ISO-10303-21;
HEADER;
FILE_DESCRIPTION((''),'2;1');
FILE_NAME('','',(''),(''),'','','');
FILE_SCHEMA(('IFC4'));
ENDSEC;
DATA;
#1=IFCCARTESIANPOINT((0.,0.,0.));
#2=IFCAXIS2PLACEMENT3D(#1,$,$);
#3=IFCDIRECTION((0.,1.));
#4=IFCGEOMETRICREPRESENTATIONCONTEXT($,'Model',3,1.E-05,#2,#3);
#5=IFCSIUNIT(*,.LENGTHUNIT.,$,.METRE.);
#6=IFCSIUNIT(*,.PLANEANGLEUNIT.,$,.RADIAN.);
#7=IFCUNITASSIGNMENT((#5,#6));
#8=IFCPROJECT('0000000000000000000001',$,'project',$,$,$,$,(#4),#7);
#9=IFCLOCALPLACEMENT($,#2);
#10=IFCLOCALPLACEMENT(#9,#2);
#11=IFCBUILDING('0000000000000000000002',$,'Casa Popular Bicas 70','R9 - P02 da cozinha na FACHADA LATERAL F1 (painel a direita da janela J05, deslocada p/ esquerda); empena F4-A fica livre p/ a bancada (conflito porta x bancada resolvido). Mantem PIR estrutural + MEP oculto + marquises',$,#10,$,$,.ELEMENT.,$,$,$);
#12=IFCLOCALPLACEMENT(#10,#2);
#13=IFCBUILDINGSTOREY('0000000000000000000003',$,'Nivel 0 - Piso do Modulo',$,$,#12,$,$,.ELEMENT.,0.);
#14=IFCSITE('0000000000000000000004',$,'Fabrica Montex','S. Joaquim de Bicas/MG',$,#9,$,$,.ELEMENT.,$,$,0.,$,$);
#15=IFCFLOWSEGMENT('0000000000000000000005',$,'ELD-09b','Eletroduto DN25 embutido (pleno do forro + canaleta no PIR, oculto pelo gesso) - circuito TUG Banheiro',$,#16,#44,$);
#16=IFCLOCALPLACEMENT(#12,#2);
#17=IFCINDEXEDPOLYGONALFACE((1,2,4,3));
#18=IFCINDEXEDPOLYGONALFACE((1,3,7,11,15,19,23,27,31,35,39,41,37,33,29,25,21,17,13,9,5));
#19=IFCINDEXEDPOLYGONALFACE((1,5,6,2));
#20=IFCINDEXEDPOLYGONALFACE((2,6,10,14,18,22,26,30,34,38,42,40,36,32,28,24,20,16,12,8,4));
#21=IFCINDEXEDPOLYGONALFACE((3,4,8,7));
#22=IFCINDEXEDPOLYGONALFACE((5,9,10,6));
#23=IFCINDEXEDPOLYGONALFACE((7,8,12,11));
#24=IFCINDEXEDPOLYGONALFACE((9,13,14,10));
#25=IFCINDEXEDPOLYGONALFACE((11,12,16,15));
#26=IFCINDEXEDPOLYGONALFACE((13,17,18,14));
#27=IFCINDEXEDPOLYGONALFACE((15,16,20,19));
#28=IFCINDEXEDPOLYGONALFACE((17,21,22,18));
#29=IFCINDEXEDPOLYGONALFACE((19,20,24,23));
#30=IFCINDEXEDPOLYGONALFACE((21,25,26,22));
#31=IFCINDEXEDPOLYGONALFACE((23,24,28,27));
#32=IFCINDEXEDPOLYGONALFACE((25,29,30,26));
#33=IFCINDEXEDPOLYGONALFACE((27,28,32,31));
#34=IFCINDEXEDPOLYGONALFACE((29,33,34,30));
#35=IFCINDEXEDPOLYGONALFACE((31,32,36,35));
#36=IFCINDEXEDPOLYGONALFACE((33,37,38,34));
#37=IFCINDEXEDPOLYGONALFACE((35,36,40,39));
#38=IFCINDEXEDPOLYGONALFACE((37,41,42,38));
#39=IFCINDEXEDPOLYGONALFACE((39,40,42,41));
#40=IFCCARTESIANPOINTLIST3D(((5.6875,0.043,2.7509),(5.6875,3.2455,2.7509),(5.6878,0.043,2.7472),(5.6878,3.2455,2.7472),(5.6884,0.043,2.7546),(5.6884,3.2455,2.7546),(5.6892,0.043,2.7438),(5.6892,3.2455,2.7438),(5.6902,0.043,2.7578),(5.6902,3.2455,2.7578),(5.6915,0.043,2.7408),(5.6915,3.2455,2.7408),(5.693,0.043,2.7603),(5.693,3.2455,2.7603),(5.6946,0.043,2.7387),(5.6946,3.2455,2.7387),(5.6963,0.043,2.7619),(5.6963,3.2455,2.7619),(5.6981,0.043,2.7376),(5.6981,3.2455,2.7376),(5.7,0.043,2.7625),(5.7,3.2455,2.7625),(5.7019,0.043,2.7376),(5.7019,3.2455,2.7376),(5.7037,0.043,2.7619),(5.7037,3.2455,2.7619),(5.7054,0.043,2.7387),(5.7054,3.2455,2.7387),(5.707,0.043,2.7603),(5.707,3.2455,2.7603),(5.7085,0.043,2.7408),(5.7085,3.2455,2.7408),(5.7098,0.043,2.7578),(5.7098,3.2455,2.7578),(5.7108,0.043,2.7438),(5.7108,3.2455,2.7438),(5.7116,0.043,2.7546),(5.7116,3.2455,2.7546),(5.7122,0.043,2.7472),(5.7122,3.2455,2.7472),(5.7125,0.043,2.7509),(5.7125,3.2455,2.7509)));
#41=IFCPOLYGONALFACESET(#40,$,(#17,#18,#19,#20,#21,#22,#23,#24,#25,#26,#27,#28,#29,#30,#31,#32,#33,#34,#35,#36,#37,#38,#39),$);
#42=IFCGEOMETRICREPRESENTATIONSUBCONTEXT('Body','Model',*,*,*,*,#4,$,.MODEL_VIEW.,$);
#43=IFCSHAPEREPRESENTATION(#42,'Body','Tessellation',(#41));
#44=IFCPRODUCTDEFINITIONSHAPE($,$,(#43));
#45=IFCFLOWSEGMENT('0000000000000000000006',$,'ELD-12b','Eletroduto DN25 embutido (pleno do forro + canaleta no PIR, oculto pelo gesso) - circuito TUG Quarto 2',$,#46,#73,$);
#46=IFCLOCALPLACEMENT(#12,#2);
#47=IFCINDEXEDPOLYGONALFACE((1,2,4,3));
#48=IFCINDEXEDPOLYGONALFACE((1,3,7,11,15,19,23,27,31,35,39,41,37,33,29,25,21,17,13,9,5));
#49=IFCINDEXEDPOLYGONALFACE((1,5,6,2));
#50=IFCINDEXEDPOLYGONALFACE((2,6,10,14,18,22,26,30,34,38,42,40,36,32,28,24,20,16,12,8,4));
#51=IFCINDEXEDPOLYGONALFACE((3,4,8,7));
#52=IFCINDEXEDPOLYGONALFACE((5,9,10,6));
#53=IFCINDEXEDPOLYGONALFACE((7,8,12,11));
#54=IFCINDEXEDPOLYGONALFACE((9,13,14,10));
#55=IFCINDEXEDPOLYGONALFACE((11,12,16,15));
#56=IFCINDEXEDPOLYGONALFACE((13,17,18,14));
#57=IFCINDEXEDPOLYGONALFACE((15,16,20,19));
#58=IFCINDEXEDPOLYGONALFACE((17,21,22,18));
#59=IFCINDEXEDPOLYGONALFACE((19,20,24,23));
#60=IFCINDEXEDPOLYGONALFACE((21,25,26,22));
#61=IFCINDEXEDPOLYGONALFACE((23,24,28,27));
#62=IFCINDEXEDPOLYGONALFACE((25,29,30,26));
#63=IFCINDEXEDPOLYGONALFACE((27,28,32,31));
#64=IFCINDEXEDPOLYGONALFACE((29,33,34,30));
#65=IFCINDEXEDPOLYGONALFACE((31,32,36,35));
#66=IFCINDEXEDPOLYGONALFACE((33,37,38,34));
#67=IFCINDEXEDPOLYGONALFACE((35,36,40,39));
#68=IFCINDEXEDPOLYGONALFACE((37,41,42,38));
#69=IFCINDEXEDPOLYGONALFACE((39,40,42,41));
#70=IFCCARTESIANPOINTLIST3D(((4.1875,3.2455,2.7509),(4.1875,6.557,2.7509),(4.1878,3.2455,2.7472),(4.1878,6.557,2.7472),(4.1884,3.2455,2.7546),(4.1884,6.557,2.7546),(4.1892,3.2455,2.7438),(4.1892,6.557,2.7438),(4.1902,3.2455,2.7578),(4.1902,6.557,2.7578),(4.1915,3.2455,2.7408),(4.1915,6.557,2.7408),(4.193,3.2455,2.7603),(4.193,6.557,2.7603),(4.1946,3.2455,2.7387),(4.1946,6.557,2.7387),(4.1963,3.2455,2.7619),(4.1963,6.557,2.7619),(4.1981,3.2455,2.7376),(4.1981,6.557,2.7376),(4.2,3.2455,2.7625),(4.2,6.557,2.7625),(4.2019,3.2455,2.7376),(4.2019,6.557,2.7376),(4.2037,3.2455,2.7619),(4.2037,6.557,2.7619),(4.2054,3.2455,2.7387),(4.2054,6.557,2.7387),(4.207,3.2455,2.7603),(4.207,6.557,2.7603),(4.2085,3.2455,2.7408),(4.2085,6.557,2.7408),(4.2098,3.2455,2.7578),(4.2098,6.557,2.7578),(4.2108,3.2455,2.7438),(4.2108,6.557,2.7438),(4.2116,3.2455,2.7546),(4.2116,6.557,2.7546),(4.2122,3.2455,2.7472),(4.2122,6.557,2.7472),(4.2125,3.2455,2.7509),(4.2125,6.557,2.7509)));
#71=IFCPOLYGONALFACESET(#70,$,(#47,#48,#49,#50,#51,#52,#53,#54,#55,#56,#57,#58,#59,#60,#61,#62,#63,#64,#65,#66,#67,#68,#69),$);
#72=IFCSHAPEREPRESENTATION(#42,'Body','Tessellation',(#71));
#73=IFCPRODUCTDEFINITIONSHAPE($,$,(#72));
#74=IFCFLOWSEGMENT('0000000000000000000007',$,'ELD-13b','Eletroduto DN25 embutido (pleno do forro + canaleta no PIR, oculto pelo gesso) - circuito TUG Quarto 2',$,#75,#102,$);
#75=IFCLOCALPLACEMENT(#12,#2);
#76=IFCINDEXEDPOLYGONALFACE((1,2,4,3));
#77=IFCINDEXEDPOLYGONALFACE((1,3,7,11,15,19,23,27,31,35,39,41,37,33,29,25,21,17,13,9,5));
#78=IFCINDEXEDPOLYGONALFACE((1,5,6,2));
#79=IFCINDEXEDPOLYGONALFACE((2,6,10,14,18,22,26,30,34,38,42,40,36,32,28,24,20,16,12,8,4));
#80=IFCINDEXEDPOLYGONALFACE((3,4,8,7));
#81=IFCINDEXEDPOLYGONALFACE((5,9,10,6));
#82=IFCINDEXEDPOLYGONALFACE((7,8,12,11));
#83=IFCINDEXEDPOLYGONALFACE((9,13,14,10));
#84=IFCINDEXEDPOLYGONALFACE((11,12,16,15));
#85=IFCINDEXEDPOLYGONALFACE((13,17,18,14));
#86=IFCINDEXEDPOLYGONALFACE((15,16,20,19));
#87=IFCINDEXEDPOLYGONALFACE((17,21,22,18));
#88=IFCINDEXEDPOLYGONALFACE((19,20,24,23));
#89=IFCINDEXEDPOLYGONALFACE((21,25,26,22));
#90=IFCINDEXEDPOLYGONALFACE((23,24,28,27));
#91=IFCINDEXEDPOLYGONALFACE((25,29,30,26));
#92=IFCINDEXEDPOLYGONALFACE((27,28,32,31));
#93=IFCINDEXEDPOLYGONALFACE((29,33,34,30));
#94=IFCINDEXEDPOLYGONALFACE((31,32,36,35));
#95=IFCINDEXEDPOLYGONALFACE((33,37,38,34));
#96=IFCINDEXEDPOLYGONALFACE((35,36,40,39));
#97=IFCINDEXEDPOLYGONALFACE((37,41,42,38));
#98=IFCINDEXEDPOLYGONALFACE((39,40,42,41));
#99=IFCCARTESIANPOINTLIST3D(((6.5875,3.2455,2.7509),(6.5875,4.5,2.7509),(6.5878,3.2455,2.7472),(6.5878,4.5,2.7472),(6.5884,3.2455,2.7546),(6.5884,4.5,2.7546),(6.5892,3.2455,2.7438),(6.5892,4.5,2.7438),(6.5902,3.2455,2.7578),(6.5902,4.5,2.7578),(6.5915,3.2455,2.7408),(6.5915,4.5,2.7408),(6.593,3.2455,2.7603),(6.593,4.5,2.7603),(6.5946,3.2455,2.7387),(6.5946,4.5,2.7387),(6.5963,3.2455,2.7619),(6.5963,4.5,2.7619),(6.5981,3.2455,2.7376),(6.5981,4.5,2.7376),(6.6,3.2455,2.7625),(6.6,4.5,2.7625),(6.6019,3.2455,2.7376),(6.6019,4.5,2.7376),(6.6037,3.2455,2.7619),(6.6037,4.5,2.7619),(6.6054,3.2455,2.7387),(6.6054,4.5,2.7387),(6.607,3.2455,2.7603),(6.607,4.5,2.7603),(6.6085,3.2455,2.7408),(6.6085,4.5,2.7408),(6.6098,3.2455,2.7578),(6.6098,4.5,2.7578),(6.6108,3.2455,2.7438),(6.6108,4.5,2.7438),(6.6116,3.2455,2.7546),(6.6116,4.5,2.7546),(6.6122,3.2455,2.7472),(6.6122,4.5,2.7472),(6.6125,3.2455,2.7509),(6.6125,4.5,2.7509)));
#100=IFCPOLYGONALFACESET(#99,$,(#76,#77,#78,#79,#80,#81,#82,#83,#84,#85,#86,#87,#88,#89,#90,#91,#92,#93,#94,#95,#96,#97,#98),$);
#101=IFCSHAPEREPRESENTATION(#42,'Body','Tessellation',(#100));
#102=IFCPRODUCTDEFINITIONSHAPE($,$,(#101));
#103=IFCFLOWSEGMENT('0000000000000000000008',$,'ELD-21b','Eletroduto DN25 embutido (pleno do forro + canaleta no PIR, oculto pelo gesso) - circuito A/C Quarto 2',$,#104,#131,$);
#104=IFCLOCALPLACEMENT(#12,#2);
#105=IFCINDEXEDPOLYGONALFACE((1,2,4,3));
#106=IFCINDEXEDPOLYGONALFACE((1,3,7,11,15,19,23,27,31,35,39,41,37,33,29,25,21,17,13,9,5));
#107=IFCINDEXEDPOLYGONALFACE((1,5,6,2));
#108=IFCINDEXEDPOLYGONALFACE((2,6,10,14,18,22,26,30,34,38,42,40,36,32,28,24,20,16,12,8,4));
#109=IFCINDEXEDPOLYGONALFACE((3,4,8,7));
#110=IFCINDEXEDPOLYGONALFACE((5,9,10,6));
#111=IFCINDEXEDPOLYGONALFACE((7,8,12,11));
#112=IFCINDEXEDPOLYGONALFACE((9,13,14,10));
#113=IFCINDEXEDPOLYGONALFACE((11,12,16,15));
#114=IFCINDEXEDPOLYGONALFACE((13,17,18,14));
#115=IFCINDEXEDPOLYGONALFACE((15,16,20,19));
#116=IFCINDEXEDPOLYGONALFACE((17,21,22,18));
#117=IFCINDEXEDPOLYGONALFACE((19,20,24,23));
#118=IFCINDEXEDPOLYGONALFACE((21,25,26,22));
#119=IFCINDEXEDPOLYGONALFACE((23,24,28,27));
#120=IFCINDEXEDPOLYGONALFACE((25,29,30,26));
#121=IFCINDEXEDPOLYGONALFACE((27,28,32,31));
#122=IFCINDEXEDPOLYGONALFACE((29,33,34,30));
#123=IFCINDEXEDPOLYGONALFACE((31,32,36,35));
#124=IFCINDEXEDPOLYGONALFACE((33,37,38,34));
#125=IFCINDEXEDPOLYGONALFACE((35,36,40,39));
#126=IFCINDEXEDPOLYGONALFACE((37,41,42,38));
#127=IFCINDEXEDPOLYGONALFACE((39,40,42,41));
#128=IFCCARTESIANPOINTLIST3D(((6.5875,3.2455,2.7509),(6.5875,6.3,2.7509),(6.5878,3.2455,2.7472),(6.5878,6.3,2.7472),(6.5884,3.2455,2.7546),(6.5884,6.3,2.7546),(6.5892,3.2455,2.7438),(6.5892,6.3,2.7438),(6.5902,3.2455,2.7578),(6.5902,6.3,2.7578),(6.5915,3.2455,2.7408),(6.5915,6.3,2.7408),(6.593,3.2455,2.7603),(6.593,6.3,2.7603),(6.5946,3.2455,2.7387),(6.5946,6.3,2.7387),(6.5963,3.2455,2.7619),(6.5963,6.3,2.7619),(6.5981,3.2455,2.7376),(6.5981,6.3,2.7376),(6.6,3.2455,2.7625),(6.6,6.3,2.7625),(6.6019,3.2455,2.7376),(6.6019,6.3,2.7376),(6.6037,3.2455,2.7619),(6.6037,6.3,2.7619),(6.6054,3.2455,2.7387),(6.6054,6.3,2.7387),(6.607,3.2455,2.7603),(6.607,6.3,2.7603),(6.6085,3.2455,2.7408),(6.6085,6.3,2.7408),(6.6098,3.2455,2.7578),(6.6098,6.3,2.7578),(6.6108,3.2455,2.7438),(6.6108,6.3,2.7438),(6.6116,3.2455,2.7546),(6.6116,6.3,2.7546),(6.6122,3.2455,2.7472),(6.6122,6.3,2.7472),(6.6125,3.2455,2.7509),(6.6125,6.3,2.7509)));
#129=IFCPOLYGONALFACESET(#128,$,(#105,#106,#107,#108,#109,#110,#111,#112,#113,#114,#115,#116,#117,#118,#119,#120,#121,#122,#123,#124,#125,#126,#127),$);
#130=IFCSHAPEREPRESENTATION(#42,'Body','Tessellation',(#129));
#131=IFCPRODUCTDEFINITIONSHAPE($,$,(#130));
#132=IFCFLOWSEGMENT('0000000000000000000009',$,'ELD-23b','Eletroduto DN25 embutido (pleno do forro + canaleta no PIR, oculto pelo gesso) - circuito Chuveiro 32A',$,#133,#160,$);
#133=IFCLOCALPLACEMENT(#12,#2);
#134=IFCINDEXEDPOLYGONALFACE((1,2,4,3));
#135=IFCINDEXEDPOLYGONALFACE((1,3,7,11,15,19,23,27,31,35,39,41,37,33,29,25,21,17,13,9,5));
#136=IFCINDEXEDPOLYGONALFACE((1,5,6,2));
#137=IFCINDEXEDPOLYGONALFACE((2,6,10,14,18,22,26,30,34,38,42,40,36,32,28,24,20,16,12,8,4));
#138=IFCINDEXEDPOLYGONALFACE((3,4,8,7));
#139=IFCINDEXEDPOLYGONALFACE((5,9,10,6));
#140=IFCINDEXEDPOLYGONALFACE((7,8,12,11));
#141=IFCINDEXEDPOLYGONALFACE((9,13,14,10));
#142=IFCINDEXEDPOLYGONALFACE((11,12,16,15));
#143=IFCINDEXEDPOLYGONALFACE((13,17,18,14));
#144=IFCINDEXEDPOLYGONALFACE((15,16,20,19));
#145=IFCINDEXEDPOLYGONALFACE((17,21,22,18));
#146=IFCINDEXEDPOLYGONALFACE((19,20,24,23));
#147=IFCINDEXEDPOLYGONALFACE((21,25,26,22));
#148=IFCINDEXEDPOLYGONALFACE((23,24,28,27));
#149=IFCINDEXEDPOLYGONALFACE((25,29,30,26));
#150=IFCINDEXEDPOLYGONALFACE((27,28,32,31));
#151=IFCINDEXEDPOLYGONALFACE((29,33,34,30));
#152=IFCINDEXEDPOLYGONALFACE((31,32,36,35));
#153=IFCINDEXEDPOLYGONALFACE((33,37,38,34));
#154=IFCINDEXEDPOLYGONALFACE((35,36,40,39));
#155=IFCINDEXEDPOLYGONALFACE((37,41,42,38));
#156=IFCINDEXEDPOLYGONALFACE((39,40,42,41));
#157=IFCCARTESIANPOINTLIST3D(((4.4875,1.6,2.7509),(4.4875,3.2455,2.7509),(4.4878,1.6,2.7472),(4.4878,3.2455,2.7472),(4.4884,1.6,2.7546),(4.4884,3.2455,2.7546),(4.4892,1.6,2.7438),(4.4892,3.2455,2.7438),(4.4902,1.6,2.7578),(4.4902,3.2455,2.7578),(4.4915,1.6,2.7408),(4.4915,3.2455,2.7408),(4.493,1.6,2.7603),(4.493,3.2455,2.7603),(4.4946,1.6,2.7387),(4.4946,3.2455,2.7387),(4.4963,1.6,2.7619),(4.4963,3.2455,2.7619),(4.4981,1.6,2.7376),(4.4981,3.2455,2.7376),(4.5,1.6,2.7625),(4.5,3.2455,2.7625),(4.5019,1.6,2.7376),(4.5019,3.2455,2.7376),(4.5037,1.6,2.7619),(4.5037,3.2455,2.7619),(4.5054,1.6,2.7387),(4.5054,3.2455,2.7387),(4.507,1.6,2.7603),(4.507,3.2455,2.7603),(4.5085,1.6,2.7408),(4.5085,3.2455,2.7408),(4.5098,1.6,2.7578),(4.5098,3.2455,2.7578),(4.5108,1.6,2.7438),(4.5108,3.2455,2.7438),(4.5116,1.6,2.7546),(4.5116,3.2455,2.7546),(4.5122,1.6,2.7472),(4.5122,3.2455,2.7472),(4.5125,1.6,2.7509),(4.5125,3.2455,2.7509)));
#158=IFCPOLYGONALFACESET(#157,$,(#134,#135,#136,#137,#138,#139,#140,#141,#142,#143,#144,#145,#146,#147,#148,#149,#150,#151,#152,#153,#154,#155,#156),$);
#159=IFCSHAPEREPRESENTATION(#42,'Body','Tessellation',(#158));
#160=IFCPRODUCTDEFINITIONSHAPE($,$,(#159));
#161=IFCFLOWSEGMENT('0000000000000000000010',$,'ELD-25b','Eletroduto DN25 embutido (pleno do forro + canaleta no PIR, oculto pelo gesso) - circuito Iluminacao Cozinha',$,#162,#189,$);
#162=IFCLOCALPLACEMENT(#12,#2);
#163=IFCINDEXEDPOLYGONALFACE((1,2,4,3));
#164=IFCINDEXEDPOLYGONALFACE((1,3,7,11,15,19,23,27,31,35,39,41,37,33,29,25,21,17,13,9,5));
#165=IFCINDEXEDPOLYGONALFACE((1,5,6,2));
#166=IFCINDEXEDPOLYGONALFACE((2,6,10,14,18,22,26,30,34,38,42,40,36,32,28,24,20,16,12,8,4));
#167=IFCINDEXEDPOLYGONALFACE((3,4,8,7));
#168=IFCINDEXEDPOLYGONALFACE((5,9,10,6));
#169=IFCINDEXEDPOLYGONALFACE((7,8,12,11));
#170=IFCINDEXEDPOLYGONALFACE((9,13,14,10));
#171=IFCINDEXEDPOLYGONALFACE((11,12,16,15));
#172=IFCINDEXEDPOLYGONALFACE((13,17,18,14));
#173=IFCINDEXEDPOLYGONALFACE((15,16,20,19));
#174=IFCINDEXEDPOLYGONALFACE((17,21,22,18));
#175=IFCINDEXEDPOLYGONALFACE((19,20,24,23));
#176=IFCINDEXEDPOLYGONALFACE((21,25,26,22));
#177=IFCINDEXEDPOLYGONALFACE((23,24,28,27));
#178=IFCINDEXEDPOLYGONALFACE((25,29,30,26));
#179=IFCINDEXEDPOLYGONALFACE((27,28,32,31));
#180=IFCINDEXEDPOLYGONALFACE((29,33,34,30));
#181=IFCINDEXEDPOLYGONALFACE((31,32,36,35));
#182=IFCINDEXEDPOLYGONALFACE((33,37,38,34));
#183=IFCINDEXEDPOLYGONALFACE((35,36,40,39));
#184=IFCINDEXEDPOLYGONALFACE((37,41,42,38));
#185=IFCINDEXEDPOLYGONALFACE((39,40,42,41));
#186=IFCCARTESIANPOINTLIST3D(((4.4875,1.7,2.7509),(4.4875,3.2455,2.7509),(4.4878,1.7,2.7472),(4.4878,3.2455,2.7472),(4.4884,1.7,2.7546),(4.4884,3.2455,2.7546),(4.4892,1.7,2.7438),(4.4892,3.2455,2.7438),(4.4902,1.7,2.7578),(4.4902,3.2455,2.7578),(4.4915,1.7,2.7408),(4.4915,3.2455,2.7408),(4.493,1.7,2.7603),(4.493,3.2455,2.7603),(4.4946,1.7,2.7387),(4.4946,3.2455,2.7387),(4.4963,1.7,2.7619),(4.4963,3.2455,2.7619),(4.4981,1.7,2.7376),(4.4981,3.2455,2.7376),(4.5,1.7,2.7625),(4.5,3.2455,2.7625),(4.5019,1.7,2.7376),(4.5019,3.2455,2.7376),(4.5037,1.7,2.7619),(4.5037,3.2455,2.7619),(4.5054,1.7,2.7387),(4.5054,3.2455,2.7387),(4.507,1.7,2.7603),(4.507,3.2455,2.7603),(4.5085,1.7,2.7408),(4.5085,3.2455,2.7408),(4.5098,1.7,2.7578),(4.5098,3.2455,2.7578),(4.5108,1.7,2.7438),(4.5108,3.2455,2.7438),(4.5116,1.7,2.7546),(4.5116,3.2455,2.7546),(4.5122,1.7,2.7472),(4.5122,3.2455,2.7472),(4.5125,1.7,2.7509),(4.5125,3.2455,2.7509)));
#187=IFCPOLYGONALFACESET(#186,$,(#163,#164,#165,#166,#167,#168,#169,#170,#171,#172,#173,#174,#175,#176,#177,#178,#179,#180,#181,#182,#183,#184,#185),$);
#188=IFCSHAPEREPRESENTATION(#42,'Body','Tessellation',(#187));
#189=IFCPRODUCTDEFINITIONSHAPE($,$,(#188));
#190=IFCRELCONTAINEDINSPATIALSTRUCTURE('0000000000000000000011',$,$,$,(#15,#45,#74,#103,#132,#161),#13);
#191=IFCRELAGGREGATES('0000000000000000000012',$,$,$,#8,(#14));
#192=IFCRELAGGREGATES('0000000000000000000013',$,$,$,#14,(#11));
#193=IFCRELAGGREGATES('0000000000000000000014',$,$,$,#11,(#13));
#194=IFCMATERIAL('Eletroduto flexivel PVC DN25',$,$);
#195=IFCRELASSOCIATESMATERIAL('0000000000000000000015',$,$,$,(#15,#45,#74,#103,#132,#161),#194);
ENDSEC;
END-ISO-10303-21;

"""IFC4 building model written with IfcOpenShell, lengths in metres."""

from ifc_helpers import new_model, si_unit, direction, frame, origin, origin_2d, place, context, subcontext, project, spatial, circle, extrude, material, element, save


model = new_model("IFC4")

# Units and contexts
model_context = context("Model", 3, precision=1e-05, world=origin(), true_north=direction((0.0, 1.0)))
body_context = subcontext(model_context, "Body", "Model", "MODEL_VIEW")
ifc_project = project(units=[si_unit("LENGTHUNIT", "METRE"), si_unit("PLANEANGLEUNIT", "RADIAN")], contexts=[model_context])

# Site, building, storey
site_placement = place(None, origin())
site = spatial("IfcSite", under=ifc_project, at=site_placement, Name="Fabrica Montex", Description="S. Joaquim de Bicas/MG", CompositionType="ELEMENT", RefElevation=0.0)
building_placement = place(site_placement, origin())
building = spatial("IfcBuilding", under=site, at=building_placement, Name="Casa Popular Bicas 70", Description="R9 - P02 da cozinha na FACHADA LATERAL F1 (painel a direita da janela J05, deslocada p/ esquerda); empena F4-A fica livre p/ a bancada (conflito porta x bancada resolvido). Mantem PIR estrutural + MEP oculto + marquises", CompositionType="ELEMENT")
storey_placement = place(building_placement, origin())
storey = spatial("IfcBuildingStorey", under=building, at=storey_placement, Name="Nivel 0 - Piso do Modulo", CompositionType="ELEMENT", Elevation=0.0)

# Flow segments
ifc_material_1 = material(Name="Eletroduto flexivel PVC DN25")
for number, where, z_axis, x_axis, name in (
    (1, (5.7, 3.2455, 2.75), (0.0, -1.0, 0.0), (0.0, 0.0, 1.0), "ELD-09b"),
):
    element("IfcFlowSegment", number, at=place(storey_placement, frame(where, z_axis=z_axis, x_axis=x_axis)), inside=storey, material=ifc_material_1, Name=name, Description="Eletroduto DN25 embutido (pleno do forro + canaleta no PIR, oculto pelo gesso) - circuito TUG Banheiro", context=body_context, shape_type="SweptSolid", body=[
        extrude(circle(Radius=0.0125, at=origin_2d()), origin(), (0.0, 0.0, 1.0), 3.2025),
    ])
flow_segment_1_placement = place(storey_placement, frame((4.2, 3.2455, 2.75), z_axis=(0.0, 1.0, 0.0), x_axis=(0.0, 0.0, 1.0)))
element("IfcFlowSegment", 2, at=flow_segment_1_placement, inside=storey, material=ifc_material_1, Name="ELD-12b", Description="Eletroduto DN25 embutido (pleno do forro + canaleta no PIR, oculto pelo gesso) - circuito TUG Quarto 2", context=body_context, shape_type="SweptSolid", body=[
    extrude(circle(Radius=0.0125, at=origin_2d()), origin(), (0.0, 0.0, 1.0), 3.3115),
])
flow_segment_2_placement = place(storey_placement, frame((6.6, 3.2455, 2.75), z_axis=(0.0, 1.0, 0.0), x_axis=(0.0, 0.0, 1.0)))
element("IfcFlowSegment", 3, at=flow_segment_2_placement, inside=storey, material=ifc_material_1, Name="ELD-13b", Description="Eletroduto DN25 embutido (pleno do forro + canaleta no PIR, oculto pelo gesso) - circuito TUG Quarto 2", context=body_context, shape_type="SweptSolid", body=[
    extrude(circle(Radius=0.0125, at=origin_2d()), origin(), (0.0, 0.0, 1.0), 1.2545),
])
flow_segment_3_placement = place(storey_placement, frame((6.6, 3.2455, 2.75), z_axis=(0.0, 1.0, 0.0), x_axis=(0.0, 0.0, 1.0)))
element("IfcFlowSegment", 4, at=flow_segment_3_placement, inside=storey, material=ifc_material_1, Name="ELD-21b", Description="Eletroduto DN25 embutido (pleno do forro + canaleta no PIR, oculto pelo gesso) - circuito A/C Quarto 2", context=body_context, shape_type="SweptSolid", body=[
    extrude(circle(Radius=0.0125, at=origin_2d()), origin(), (0.0, 0.0, 1.0), 3.0545),
])
flow_segment_4_placement = place(storey_placement, frame((4.5, 3.2455, 2.75), z_axis=(0.0, -1.0, 0.0), x_axis=(0.0, 0.0, 1.0)))
element("IfcFlowSegment", 5, at=flow_segment_4_placement, inside=storey, material=ifc_material_1, Name="ELD-23b", Description="Eletroduto DN25 embutido (pleno do forro + canaleta no PIR, oculto pelo gesso) - circuito Chuveiro 32A", context=body_context, shape_type="SweptSolid", body=[
    extrude(circle(Radius=0.0125, at=origin_2d()), origin(), (0.0, 0.0, 1.0), 1.6455),
])
flow_segment_5_placement = place(storey_placement, frame((4.5, 3.2455, 2.75), z_axis=(0.0, -1.0, 0.0), x_axis=(0.0, 0.0, 1.0)))
element("IfcFlowSegment", 6, at=flow_segment_5_placement, inside=storey, material=ifc_material_1, Name="ELD-25b", Description="Eletroduto DN25 embutido (pleno do forro + canaleta no PIR, oculto pelo gesso) - circuito Iluminacao Cozinha", context=body_context, shape_type="SweptSolid", body=[
    extrude(circle(Radius=0.0125, at=origin_2d()), origin(), (0.0, 0.0, 1.0), 1.5455),
])

save(model, "model.ifc")
